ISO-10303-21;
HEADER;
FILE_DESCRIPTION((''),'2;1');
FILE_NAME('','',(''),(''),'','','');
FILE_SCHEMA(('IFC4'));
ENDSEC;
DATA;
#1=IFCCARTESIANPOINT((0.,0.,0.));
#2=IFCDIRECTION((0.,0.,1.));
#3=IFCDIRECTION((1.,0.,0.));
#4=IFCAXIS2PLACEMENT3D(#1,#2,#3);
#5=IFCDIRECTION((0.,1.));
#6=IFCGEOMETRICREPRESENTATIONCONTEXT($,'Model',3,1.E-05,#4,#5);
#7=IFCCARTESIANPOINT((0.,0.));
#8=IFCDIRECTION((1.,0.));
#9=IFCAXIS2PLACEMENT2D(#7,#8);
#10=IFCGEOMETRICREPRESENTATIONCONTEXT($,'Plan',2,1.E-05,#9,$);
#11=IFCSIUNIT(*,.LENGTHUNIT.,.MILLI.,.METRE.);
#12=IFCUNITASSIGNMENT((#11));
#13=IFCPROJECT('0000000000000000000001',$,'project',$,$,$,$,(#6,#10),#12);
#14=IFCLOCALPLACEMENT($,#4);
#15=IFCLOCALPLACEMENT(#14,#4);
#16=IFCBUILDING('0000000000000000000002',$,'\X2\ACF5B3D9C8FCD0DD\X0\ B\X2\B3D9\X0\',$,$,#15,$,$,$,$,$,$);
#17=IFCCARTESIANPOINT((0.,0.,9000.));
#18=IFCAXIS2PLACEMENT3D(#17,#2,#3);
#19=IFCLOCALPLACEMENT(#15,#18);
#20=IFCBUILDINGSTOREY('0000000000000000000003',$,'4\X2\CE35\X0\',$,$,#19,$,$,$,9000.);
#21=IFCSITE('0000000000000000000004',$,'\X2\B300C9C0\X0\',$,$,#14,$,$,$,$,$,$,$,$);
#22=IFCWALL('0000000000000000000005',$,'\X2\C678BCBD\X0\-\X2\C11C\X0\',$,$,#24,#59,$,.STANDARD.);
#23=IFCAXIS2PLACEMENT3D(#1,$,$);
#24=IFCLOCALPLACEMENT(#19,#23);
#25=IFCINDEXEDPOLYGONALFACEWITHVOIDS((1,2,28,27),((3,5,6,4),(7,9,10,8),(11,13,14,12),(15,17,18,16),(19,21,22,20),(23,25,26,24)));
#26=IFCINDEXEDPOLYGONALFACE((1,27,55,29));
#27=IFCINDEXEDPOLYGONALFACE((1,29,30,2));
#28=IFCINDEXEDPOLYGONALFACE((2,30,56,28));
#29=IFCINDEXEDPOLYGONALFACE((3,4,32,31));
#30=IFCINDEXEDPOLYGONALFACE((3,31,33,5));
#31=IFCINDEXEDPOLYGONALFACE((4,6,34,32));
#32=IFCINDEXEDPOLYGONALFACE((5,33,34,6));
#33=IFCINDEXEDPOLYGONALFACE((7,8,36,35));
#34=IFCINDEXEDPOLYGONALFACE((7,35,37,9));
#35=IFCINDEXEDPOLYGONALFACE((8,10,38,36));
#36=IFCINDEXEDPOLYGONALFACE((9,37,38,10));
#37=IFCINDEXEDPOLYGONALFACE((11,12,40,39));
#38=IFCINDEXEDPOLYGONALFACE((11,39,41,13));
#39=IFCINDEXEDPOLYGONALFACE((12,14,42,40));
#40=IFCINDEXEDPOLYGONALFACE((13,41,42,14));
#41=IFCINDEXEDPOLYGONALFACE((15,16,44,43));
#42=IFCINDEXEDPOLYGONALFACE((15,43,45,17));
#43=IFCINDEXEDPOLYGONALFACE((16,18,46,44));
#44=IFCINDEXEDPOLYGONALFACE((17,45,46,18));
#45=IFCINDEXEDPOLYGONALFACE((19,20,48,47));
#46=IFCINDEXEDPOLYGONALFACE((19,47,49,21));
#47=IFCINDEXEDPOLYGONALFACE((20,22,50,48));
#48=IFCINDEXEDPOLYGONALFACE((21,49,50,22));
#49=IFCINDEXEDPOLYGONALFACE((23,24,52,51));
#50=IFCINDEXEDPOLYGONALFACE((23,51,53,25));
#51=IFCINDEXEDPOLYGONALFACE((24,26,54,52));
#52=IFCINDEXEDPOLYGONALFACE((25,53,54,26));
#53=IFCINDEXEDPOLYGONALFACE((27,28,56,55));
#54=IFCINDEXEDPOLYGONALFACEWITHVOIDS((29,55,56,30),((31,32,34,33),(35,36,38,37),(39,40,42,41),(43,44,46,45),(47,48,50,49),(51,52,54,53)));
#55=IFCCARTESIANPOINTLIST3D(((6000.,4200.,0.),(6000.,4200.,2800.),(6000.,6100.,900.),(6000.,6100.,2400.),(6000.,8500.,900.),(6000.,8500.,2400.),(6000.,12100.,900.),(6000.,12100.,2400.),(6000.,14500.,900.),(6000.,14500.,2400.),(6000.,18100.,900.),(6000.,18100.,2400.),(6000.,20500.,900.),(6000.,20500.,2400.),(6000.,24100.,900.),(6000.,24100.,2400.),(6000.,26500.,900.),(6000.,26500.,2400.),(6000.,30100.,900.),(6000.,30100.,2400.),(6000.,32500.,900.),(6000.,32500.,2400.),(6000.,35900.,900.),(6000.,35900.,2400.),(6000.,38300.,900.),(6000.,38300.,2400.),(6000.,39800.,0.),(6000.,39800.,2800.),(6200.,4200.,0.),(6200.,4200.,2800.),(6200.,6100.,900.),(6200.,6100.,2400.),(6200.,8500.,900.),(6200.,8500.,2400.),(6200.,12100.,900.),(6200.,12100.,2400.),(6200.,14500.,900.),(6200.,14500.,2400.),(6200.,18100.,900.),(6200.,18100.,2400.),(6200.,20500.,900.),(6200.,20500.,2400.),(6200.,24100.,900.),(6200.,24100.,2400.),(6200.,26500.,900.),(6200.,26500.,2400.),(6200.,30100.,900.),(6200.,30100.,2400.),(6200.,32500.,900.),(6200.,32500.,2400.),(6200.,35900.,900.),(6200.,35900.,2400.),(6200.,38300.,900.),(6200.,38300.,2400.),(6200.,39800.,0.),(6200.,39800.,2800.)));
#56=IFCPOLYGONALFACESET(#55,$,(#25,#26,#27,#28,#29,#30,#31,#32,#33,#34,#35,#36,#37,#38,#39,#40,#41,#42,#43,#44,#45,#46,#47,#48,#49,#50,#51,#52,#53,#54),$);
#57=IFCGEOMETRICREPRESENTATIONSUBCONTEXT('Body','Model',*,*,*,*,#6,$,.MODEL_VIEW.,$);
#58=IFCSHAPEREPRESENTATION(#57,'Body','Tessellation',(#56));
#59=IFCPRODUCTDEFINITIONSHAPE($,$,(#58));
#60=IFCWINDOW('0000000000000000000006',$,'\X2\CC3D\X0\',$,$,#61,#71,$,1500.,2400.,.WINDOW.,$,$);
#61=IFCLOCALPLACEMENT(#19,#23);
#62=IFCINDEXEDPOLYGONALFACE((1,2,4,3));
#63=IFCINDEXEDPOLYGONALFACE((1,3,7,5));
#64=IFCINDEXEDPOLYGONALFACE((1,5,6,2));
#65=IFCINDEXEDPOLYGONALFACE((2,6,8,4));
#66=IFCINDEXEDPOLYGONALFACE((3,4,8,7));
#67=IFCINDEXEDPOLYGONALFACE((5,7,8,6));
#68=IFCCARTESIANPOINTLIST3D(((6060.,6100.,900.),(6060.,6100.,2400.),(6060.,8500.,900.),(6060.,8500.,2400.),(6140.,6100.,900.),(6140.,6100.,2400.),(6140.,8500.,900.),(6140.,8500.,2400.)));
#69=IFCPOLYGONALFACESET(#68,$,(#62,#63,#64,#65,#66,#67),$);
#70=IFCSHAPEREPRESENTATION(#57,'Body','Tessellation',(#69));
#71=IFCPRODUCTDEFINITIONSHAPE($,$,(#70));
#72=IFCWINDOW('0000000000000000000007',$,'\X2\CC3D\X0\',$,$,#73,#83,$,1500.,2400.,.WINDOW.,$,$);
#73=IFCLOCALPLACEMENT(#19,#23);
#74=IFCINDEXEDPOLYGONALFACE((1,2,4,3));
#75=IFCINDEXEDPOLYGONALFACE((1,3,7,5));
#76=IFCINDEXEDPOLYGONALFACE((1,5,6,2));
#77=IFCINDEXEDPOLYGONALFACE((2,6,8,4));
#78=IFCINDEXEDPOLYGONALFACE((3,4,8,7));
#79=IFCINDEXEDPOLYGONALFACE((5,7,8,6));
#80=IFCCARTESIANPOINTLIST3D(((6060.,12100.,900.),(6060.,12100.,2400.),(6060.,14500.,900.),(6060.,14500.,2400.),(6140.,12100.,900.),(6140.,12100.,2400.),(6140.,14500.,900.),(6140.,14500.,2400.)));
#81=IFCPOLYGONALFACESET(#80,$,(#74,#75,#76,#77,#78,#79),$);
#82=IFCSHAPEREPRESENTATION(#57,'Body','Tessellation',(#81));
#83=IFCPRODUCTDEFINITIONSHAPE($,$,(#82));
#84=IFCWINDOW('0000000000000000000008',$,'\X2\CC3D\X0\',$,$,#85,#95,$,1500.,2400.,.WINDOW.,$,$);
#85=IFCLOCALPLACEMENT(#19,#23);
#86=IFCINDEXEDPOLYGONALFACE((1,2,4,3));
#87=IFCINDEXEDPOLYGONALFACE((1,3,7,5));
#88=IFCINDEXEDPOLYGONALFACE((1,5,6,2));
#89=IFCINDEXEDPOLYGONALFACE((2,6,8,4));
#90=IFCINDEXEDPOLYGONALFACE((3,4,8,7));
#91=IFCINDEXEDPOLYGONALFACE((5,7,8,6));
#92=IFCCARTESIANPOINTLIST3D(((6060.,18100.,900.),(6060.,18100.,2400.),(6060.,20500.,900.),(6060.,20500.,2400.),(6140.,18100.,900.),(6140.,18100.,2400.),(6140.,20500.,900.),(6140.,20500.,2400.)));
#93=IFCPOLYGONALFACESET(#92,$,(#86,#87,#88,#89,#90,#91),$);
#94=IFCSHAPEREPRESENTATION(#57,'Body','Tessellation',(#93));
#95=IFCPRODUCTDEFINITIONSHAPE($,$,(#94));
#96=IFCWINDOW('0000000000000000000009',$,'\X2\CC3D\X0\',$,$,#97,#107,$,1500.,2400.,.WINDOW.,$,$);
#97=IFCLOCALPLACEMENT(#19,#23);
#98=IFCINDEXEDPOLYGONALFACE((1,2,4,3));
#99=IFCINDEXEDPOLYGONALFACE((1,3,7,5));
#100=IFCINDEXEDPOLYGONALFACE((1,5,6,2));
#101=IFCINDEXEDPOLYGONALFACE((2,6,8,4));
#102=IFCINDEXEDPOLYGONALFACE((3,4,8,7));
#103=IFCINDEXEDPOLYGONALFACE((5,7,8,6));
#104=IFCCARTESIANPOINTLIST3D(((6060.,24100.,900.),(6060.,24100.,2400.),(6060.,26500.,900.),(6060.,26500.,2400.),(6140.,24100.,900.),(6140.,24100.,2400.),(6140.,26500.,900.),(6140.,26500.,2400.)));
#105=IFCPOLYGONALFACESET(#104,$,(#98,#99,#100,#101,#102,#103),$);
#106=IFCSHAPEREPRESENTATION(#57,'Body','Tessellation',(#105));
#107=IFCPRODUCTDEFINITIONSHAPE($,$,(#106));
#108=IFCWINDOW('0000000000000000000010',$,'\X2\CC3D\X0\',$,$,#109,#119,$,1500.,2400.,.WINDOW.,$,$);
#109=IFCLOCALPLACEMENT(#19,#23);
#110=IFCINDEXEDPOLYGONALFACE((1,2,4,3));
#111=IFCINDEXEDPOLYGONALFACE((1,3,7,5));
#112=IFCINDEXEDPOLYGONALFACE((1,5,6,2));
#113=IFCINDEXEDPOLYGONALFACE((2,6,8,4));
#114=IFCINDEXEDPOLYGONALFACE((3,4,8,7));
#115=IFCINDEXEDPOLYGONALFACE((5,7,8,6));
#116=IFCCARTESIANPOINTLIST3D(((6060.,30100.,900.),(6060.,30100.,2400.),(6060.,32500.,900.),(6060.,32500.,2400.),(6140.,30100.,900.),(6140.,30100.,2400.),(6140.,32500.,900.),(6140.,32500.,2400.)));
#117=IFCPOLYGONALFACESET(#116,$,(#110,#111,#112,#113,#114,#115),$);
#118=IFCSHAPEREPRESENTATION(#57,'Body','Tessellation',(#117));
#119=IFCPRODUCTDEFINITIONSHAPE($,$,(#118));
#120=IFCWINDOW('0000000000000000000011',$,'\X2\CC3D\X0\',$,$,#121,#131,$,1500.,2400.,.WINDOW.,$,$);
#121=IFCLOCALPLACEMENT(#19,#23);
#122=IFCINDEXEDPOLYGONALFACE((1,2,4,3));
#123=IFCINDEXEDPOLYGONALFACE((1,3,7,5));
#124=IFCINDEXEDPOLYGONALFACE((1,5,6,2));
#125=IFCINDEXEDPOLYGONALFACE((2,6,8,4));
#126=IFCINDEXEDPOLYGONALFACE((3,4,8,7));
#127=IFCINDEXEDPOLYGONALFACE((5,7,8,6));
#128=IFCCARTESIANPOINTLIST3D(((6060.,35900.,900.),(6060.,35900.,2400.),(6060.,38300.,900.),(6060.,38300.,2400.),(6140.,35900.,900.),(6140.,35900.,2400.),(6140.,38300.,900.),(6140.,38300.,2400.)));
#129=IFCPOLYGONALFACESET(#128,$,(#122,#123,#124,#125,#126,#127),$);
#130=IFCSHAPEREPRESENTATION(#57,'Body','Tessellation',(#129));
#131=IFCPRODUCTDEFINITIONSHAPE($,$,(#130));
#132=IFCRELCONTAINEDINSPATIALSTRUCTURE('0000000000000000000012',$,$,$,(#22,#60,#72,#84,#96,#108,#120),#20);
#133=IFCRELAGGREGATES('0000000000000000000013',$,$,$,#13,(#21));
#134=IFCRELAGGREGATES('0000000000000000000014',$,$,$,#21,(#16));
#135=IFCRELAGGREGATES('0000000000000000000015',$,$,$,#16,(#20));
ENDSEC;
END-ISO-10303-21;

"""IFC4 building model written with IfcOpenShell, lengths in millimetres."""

from ifc_helpers import new_model, si_unit, direction, frame, origin_with_axes, origin_2d_with_axis, place, context, subcontext, project, spatial, polyline, outline, extrude, element, fill, save


model = new_model("IFC4")

# Units and contexts
model_context = context("Model", 3, precision=1e-05, world=origin_with_axes(), true_north=direction((0.0, 1.0)))
plan_context = context("Plan", 2, precision=1e-05, world=origin_2d_with_axis())
body_context = subcontext(model_context, "Body", "Model", "MODEL_VIEW")
ifc_project = project(units=[si_unit("LENGTHUNIT", "METRE", prefix="MILLI")], contexts=[model_context, plan_context])

# Site, building, storey
site_placement = place(None, origin_with_axes())
site = spatial("IfcSite", under=ifc_project, at=site_placement, Name="대지")
building_placement = place(site_placement, origin_with_axes())
building = spatial("IfcBuilding", under=site, at=building_placement, Name="공동주택 B동")
storey_placement = place(building_placement, frame((0.0, 0.0, 9000.0), z_axis=(0.0, 0.0, 1.0), x_axis=(1.0, 0.0, 0.0)))
storey = spatial("IfcBuildingStorey", under=building, at=storey_placement, Name="4층", Elevation=9000.0)

# Wall, openings, windows
wall_1_placement = place(storey_placement, origin_with_axes())
wall_1 = element("IfcWall", 1, at=wall_1_placement, inside=storey, Name="외벽-서", PredefinedType="STANDARD", context=body_context, shape_type="SweptSolid", body=[
    extrude(outline(polyline([(6200.0, 39800.0), (6200.0, 4200.0), (6000.0, 4200.0), (6000.0, 39800.0), (6200.0, 39800.0)])), origin_with_axes(), (0.0, 0.0, 1.0), 2800.0),
])
opening_1_placement = place(storey_placement, origin_with_axes())
opening_1 = element("IfcOpeningElement", 2, at=opening_1_placement, cuts=wall_1, PredefinedType="OPENING", context=body_context, shape_type="SweptSolid", body=[
    extrude(outline(polyline([(5950.0, 8500.0), (5950.0, 6100.0), (6250.0, 6100.0), (6250.0, 8500.0), (5950.0, 8500.0)])), frame((0.0, 0.0, 900.0), z_axis=(0.0, 0.0, 1.0), x_axis=(1.0, 0.0, 0.0)), (0.0, 0.0, 1.0), 1500.0),
])
opening_2_placement = place(storey_placement, origin_with_axes())
opening_2 = element("IfcOpeningElement", 3, at=opening_2_placement, cuts=wall_1, PredefinedType="OPENING", context=body_context, shape_type="SweptSolid", body=[
    extrude(outline(polyline([(5950.0, 14500.0), (5950.0, 12100.0), (6250.0, 12100.0), (6250.0, 14500.0), (5950.0, 14500.0)])), frame((0.0, 0.0, 900.0), z_axis=(0.0, 0.0, 1.0), x_axis=(1.0, 0.0, 0.0)), (0.0, 0.0, 1.0), 1500.0),
])
opening_3_placement = place(storey_placement, origin_with_axes())
opening_3 = element("IfcOpeningElement", 4, at=opening_3_placement, cuts=wall_1, PredefinedType="OPENING", context=body_context, shape_type="SweptSolid", body=[
    extrude(outline(polyline([(5950.0, 20500.0), (5950.0, 18100.0), (6250.0, 18100.0), (6250.0, 20500.0), (5950.0, 20500.0)])), frame((0.0, 0.0, 900.0), z_axis=(0.0, 0.0, 1.0), x_axis=(1.0, 0.0, 0.0)), (0.0, 0.0, 1.0), 1500.0),
])
opening_4_placement = place(storey_placement, origin_with_axes())
opening_4 = element("IfcOpeningElement", 5, at=opening_4_placement, cuts=wall_1, PredefinedType="OPENING", context=body_context, shape_type="SweptSolid", body=[
    extrude(outline(polyline([(5950.0, 26500.0), (5950.0, 24100.0), (6250.0, 24100.0), (6250.0, 26500.0), (5950.0, 26500.0)])), frame((0.0, 0.0, 900.0), z_axis=(0.0, 0.0, 1.0), x_axis=(1.0, 0.0, 0.0)), (0.0, 0.0, 1.0), 1500.0),
])
opening_5_placement = place(storey_placement, origin_with_axes())
opening_5 = element("IfcOpeningElement", 6, at=opening_5_placement, cuts=wall_1, PredefinedType="OPENING", context=body_context, shape_type="SweptSolid", body=[
    extrude(outline(polyline([(5950.0, 32500.0), (5950.0, 30100.0), (6250.0, 30100.0), (6250.0, 32500.0), (5950.0, 32500.0)])), frame((0.0, 0.0, 900.0), z_axis=(0.0, 0.0, 1.0), x_axis=(1.0, 0.0, 0.0)), (0.0, 0.0, 1.0), 1500.0),
])
opening_6_placement = place(storey_placement, origin_with_axes())
opening_6 = element("IfcOpeningElement", 7, at=opening_6_placement, cuts=wall_1, PredefinedType="OPENING", context=body_context, shape_type="SweptSolid", body=[
    extrude(outline(polyline([(5950.0, 38300.0), (5950.0, 35900.0), (6250.0, 35900.0), (6250.0, 38300.0), (5950.0, 38300.0)])), frame((0.0, 0.0, 900.0), z_axis=(0.0, 0.0, 1.0), x_axis=(1.0, 0.0, 0.0)), (0.0, 0.0, 1.0), 1500.0),
])
window_1_placement = place(storey_placement, origin_with_axes())
window_1 = element("IfcWindow", 8, at=window_1_placement, inside=storey, Name="창", OverallHeight=1500.0, OverallWidth=2400.0, PredefinedType="WINDOW", context=body_context, shape_type="SweptSolid", body=[
    extrude(outline(polyline([(6060.0, 8500.0), (6060.0, 6100.0), (6140.0, 6100.0), (6140.0, 8500.0), (6060.0, 8500.0)])), frame((0.0, 0.0, 900.0), z_axis=(0.0, 0.0, 1.0), x_axis=(1.0, 0.0, 0.0)), (0.0, 0.0, 1.0), 1500.0),
])
fill(opening_1, window_1)
window_2_placement = place(storey_placement, origin_with_axes())
window_2 = element("IfcWindow", 9, at=window_2_placement, inside=storey, Name="창", OverallHeight=1500.0, OverallWidth=2400.0, PredefinedType="WINDOW", context=body_context, shape_type="SweptSolid", body=[
    extrude(outline(polyline([(6060.0, 14500.0), (6060.0, 12100.0), (6140.0, 12100.0), (6140.0, 14500.0), (6060.0, 14500.0)])), frame((0.0, 0.0, 900.0), z_axis=(0.0, 0.0, 1.0), x_axis=(1.0, 0.0, 0.0)), (0.0, 0.0, 1.0), 1500.0),
])
fill(opening_2, window_2)
window_3_placement = place(storey_placement, origin_with_axes())
window_3 = element("IfcWindow", 10, at=window_3_placement, inside=storey, Name="창", OverallHeight=1500.0, OverallWidth=2400.0, PredefinedType="WINDOW", context=body_context, shape_type="SweptSolid", body=[
    extrude(outline(polyline([(6060.0, 20500.0), (6060.0, 18100.0), (6140.0, 18100.0), (6140.0, 20500.0), (6060.0, 20500.0)])), frame((0.0, 0.0, 900.0), z_axis=(0.0, 0.0, 1.0), x_axis=(1.0, 0.0, 0.0)), (0.0, 0.0, 1.0), 1500.0),
])
fill(opening_3, window_3)
window_4_placement = place(storey_placement, origin_with_axes())
window_4 = element("IfcWindow", 11, at=window_4_placement, inside=storey, Name="창", OverallHeight=1500.0, OverallWidth=2400.0, PredefinedType="WINDOW", context=body_context, shape_type="SweptSolid", body=[
    extrude(outline(polyline([(6060.0, 26500.0), (6060.0, 24100.0), (6140.0, 24100.0), (6140.0, 26500.0), (6060.0, 26500.0)])), frame((0.0, 0.0, 900.0), z_axis=(0.0, 0.0, 1.0), x_axis=(1.0, 0.0, 0.0)), (0.0, 0.0, 1.0), 1500.0),
])
fill(opening_4, window_4)
window_5_placement = place(storey_placement, origin_with_axes())
window_5 = element("IfcWindow", 12, at=window_5_placement, inside=storey, Name="창", OverallHeight=1500.0, OverallWidth=2400.0, PredefinedType="WINDOW", context=body_context, shape_type="SweptSolid", body=[
    extrude(outline(polyline([(6060.0, 32500.0), (6060.0, 30100.0), (6140.0, 30100.0), (6140.0, 32500.0), (6060.0, 32500.0)])), frame((0.0, 0.0, 900.0), z_axis=(0.0, 0.0, 1.0), x_axis=(1.0, 0.0, 0.0)), (0.0, 0.0, 1.0), 1500.0),
])
fill(opening_5, window_5)
window_6_placement = place(storey_placement, origin_with_axes())
window_6 = element("IfcWindow", 13, at=window_6_placement, inside=storey, Name="창", OverallHeight=1500.0, OverallWidth=2400.0, PredefinedType="WINDOW", context=body_context, shape_type="SweptSolid", body=[
    extrude(outline(polyline([(6060.0, 38300.0), (6060.0, 35900.0), (6140.0, 35900.0), (6140.0, 38300.0), (6060.0, 38300.0)])), frame((0.0, 0.0, 900.0), z_axis=(0.0, 0.0, 1.0), x_axis=(1.0, 0.0, 0.0)), (0.0, 0.0, 1.0), 1500.0),
])
fill(opening_6, window_6)

save(model, "model.ifc")
